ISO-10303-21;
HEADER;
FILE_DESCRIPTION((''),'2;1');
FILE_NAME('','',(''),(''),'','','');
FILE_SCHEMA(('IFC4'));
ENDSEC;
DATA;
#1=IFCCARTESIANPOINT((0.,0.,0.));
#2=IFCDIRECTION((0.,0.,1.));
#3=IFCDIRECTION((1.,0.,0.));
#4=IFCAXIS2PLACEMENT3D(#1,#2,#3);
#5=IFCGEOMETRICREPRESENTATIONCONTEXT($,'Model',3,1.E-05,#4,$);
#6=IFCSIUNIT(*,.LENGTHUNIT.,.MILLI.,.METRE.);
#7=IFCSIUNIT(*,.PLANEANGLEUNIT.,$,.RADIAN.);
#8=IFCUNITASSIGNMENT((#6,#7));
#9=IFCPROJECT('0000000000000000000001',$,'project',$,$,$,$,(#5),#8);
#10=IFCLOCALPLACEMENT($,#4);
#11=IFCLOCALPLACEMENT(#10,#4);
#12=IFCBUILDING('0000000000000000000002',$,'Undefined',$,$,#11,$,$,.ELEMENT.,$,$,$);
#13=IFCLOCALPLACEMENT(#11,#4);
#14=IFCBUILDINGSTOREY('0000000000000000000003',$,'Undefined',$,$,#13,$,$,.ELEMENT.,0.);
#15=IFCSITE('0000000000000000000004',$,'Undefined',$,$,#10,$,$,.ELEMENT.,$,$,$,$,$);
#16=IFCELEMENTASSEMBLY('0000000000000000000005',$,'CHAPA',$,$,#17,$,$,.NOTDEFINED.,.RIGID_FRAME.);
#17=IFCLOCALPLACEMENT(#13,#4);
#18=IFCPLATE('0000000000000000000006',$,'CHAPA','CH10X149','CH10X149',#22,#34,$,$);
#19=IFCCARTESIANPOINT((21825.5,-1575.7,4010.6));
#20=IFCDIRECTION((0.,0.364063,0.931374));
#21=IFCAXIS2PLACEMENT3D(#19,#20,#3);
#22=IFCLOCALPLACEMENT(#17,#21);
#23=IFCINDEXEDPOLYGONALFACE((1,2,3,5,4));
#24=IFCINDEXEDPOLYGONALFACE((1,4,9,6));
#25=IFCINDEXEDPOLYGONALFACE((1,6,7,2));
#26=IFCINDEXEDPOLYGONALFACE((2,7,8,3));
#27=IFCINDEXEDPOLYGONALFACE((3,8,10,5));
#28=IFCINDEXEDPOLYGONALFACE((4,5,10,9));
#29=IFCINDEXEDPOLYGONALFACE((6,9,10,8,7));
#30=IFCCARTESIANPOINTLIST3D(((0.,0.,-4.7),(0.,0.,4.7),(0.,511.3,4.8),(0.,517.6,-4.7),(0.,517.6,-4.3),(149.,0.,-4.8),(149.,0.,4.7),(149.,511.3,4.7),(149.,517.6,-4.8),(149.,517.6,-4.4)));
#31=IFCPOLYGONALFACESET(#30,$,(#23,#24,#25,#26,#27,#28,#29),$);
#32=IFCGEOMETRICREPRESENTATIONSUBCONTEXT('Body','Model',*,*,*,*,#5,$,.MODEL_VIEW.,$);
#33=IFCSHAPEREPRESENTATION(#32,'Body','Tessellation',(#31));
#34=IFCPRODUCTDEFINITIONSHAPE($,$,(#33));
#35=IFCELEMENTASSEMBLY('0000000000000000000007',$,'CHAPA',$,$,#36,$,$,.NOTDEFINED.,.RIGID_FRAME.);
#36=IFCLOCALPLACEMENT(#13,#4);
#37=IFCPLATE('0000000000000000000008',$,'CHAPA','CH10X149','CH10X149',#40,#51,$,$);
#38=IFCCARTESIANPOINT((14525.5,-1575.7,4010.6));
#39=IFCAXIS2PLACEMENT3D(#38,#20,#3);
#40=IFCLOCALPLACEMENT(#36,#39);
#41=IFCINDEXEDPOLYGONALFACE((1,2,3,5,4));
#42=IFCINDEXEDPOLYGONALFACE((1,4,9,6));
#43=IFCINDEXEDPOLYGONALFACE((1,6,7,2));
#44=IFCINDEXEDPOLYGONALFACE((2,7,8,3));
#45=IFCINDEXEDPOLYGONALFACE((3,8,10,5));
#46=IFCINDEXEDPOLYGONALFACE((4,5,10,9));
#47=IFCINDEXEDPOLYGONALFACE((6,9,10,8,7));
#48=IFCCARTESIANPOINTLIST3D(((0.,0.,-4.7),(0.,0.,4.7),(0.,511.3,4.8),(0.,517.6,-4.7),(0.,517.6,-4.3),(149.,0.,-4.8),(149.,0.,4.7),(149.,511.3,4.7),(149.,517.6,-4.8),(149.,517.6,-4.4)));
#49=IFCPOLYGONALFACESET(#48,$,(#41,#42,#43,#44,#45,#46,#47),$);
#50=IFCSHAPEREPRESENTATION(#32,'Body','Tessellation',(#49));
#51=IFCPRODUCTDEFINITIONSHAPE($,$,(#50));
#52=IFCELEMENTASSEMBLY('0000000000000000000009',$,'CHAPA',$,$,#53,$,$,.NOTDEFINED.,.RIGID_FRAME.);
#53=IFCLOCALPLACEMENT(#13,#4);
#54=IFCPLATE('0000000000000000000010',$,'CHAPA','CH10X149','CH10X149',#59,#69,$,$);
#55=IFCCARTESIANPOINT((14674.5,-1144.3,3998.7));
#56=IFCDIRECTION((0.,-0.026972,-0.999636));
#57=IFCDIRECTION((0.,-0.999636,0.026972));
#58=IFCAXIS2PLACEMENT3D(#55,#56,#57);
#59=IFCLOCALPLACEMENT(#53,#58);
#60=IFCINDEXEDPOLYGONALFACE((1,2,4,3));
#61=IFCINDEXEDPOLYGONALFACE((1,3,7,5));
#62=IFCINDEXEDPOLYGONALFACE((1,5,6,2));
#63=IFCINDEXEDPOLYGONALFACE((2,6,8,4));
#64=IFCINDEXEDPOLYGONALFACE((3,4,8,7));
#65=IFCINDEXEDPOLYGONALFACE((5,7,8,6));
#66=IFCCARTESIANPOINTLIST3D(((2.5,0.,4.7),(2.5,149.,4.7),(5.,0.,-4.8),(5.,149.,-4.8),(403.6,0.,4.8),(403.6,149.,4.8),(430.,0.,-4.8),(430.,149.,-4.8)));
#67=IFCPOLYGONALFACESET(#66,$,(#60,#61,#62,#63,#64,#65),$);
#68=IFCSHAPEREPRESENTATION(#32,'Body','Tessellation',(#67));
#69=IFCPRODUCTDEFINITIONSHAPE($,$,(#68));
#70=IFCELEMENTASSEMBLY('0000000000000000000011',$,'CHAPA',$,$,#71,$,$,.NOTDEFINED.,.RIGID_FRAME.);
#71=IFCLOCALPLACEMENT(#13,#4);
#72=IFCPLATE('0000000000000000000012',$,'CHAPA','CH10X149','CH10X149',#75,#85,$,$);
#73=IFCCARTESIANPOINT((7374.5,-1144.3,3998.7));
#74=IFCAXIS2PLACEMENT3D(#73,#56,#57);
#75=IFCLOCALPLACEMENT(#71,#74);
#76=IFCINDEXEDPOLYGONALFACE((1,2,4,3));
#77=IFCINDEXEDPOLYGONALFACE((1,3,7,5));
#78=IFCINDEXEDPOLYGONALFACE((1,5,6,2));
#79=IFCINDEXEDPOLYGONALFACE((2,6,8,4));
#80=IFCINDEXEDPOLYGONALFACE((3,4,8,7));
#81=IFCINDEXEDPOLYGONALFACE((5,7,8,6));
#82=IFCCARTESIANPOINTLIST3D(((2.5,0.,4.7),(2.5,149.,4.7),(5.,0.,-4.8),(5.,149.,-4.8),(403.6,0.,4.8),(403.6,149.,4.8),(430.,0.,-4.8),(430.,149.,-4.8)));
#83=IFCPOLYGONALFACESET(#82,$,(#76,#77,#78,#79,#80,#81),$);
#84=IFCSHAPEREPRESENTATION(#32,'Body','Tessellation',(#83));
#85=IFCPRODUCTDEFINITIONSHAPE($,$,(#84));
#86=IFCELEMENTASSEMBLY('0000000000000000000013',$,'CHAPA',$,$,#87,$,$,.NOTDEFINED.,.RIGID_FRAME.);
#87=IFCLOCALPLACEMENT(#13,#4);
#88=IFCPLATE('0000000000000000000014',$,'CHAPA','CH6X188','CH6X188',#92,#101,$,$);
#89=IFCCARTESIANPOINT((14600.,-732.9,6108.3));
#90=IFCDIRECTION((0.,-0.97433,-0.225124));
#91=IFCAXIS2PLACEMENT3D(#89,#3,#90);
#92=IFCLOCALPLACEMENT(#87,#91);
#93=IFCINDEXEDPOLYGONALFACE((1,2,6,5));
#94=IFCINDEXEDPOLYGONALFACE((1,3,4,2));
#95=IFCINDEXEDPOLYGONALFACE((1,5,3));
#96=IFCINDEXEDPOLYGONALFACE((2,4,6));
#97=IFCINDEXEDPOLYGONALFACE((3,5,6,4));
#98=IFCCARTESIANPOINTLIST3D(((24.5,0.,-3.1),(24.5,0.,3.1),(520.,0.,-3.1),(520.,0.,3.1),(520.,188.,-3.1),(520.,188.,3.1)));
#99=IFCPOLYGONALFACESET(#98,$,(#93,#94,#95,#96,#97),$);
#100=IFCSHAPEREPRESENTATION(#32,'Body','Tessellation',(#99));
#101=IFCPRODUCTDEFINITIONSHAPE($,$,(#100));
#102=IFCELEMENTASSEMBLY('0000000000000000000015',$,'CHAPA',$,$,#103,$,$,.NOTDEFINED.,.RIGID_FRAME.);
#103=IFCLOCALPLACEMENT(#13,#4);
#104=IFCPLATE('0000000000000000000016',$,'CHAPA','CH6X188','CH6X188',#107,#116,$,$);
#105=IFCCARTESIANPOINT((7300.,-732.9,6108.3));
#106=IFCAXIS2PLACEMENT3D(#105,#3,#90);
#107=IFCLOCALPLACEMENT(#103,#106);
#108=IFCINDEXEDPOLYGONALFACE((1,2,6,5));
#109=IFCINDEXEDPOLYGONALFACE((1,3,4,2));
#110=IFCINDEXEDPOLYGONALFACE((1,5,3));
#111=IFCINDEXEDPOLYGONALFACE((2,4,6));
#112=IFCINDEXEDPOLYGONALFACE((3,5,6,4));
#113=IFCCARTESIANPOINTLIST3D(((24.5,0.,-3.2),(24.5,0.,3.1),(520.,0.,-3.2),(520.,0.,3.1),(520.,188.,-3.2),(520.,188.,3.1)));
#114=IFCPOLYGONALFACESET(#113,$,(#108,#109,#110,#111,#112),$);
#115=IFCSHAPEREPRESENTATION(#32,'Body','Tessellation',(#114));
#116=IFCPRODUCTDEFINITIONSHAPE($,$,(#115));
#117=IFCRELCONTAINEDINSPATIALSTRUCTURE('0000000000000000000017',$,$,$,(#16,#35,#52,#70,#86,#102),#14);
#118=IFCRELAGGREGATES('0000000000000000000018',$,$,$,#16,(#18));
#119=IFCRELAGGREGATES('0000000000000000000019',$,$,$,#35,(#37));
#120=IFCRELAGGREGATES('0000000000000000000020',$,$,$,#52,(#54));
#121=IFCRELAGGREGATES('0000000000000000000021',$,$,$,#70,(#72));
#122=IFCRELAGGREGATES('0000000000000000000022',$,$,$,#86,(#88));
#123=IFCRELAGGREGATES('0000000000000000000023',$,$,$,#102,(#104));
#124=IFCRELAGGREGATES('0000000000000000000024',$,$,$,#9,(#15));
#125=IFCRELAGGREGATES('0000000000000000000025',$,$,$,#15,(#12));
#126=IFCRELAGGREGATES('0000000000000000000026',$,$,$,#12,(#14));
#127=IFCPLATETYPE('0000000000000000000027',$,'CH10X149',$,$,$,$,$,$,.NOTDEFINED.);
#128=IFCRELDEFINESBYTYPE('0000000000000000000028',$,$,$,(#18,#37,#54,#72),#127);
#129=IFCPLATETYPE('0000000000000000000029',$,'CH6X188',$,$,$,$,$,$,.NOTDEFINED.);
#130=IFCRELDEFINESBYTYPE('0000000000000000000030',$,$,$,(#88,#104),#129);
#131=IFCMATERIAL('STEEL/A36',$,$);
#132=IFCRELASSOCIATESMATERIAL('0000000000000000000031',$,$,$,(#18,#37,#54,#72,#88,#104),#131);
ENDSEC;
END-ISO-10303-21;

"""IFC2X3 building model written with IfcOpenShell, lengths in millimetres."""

from ifc_helpers import new_model, si_unit, frame, origin_with_axes, place, context, subcontext, project, spatial, polyline, outline, extrude, clip, halfspace, material, type_object, element, aggregate, save


model = new_model("IFC2X3")

# Units and contexts
model_context = context("Model", 3, precision=1e-05, world=origin_with_axes())
body_context = subcontext(model_context, "Body", "Model", "MODEL_VIEW")
ifc_project = project(units=[si_unit("LENGTHUNIT", "METRE", prefix="MILLI"), si_unit("PLANEANGLEUNIT", "RADIAN")], contexts=[model_context])

# Site, building, storey
site_placement = place(None, origin_with_axes())
site = spatial("IfcSite", under=ifc_project, at=site_placement, Name="Undefined", CompositionType="ELEMENT")
building_placement = place(site_placement, origin_with_axes())
building = spatial("IfcBuilding", under=site, at=building_placement, Name="Undefined", CompositionType="ELEMENT")
storey_placement = place(building_placement, origin_with_axes())
storey = spatial("IfcBuildingStorey", under=building, at=storey_placement, Name="Undefined", CompositionType="ELEMENT", Elevation=0.0)

# Shared definitions
ifc_material_1 = material(Name="STEEL/A36")

# Element assemblies, plates
assembly_1_placement = place(storey_placement, origin_with_axes())
assembly_1 = element("IfcElementAssembly", 1, at=assembly_1_placement, inside=storey, Name="CHAPA", AssemblyPlace="NOTDEFINED", PredefinedType="RIGID_FRAME")
plate_type_1 = type_object("IfcPlateType", Name="CH10X149", PredefinedType="NOTDEFINED")
plate_1_placement = place(assembly_1_placement, frame((21825.5, -1575.7, 4010.6), z_axis=(0.0, 0.364063, 0.931374), x_axis=(1.0, 0.0, 0.0)))
plate_1 = element("IfcPlate", 2, at=plate_1_placement, type_object=plate_type_1, material=ifc_material_1, Name="CHAPA", Description="CH10X149", ObjectType="CH10X149", context=body_context, shape_type="Clipping", body=[
    clip(extrude(outline(polyline([(0.0, 0.0), (149.0, 0.0), (149.0, 517.6), (0.0, 517.6), (0.0, 0.0)])), frame((0.0, 0.0, -4.8), z_axis=(0.0, 0.0, 1.0), x_axis=(1.0, 0.0, 0.0)), (0.0, 0.0, 1.0), 9.5), halfspace(frame((149.0, 517.9, -4.7), z_axis=(0.0, 0.821204, 0.570634), x_axis=(0.0, -0.570634, 0.821204)), False)),
])
aggregate(assembly_1, [plate_1])
assembly_2_placement = place(storey_placement, origin_with_axes())
assembly_2 = element("IfcElementAssembly", 3, at=assembly_2_placement, inside=storey, Name="CHAPA", AssemblyPlace="NOTDEFINED", PredefinedType="RIGID_FRAME")
plate_2_placement = place(assembly_2_placement, frame((14525.5, -1575.7, 4010.6), z_axis=(0.0, 0.364063, 0.931374), x_axis=(1.0, 0.0, 0.0)))
plate_2 = element("IfcPlate", 4, at=plate_2_placement, type_object=plate_type_1, material=ifc_material_1, Name="CHAPA", Description="CH10X149", ObjectType="CH10X149", context=body_context, shape_type="Clipping", body=[
    clip(extrude(outline(polyline([(0.0, 0.0), (149.0, 0.0), (149.0, 517.6), (0.0, 517.6), (0.0, 0.0)])), frame((0.0, 0.0, -4.8), z_axis=(0.0, 0.0, 1.0), x_axis=(1.0, 0.0, 0.0)), (0.0, 0.0, 1.0), 9.5), halfspace(frame((149.0, 517.9, -4.7), z_axis=(0.0, 0.821204, 0.570634), x_axis=(0.0, -0.570634, 0.821204)), False)),
])
aggregate(assembly_2, [plate_2])
assembly_3_placement = place(storey_placement, origin_with_axes())
assembly_3 = element("IfcElementAssembly", 5, at=assembly_3_placement, inside=storey, Name="CHAPA", AssemblyPlace="NOTDEFINED", PredefinedType="RIGID_FRAME")
plate_3_placement = place(assembly_3_placement, frame((14674.5, -1144.3, 3998.7), z_axis=(0.0, -0.026972, -0.999636), x_axis=(0.0, -0.999636, 0.026972)))
plate_3 = element("IfcPlate", 6, at=plate_3_placement, type_object=plate_type_1, material=ifc_material_1, Name="CHAPA", Description="CH10X149", ObjectType="CH10X149", context=body_context, shape_type="Clipping", body=[
    clip(clip(extrude(outline(polyline([(0.0, 0.0), (430.0, 0.0), (430.0, 149.0), (0.0, 149.0), (0.0, 0.0)])), frame((0.0, 0.0, -4.8), z_axis=(0.0, 0.0, 1.0), x_axis=(1.0, 0.0, 0.0)), (0.0, 0.0, 1.0), 9.5), halfspace(frame((403.6, -500.0, 4.7), z_axis=(0.33881, 0.0, 0.940855), x_axis=(0.0, 1.0, 0.0)), False)), halfspace(frame((5.0, -500.0, -4.8), z_axis=(-0.965989, 0.0, -0.258583), x_axis=(0.0, 1.0, 0.0)), False)),
])
aggregate(assembly_3, [plate_3])
assembly_4_placement = place(storey_placement, origin_with_axes())
assembly_4 = element("IfcElementAssembly", 7, at=assembly_4_placement, inside=storey, Name="CHAPA", AssemblyPlace="NOTDEFINED", PredefinedType="RIGID_FRAME")
plate_4_placement = place(assembly_4_placement, frame((7374.5, -1144.3, 3998.7), z_axis=(0.0, -0.026972, -0.999636), x_axis=(0.0, -0.999636, 0.026972)))
plate_4 = element("IfcPlate", 8, at=plate_4_placement, type_object=plate_type_1, material=ifc_material_1, Name="CHAPA", Description="CH10X149", ObjectType="CH10X149", context=body_context, shape_type="Clipping", body=[
    clip(clip(extrude(outline(polyline([(0.0, 0.0), (430.0, 0.0), (430.0, 149.0), (0.0, 149.0), (0.0, 0.0)])), frame((0.0, 0.0, -4.8), z_axis=(0.0, 0.0, 1.0), x_axis=(1.0, 0.0, 0.0)), (0.0, 0.0, 1.0), 9.5), halfspace(frame((403.6, -500.0, 4.7), z_axis=(0.33881, 0.0, 0.940855), x_axis=(0.0, 1.0, 0.0)), False)), halfspace(frame((5.0, -500.0, -4.8), z_axis=(-0.965989, 0.0, -0.258583), x_axis=(0.0, 1.0, 0.0)), False)),
])
aggregate(assembly_4, [plate_4])
assembly_5_placement = place(storey_placement, origin_with_axes())
assembly_5 = element("IfcElementAssembly", 9, at=assembly_5_placement, inside=storey, Name="CHAPA", AssemblyPlace="NOTDEFINED", PredefinedType="RIGID_FRAME")
plate_type_2 = type_object("IfcPlateType", Name="CH6X188", PredefinedType="NOTDEFINED")
plate_5_placement = place(assembly_5_placement, frame((14600.0, -732.9, 6108.3), z_axis=(1.0, 0.0, 0.0), x_axis=(0.0, -0.97433, -0.225124)))
plate_5 = element("IfcPlate", 10, at=plate_5_placement, type_object=plate_type_2, material=ifc_material_1, Name="CHAPA", Description="CH6X188", ObjectType="CH6X188", context=body_context, shape_type="Clipping", body=[
    clip(extrude(outline(polyline([(0.0, 0.0), (520.0, 0.0), (520.0, 191.6), (0.0, 0.0)])), frame((0.0, 0.0, -3.1), z_axis=(0.0, 0.0, 1.0), x_axis=(1.0, 0.0, 0.0)), (0.0, 0.0, 1.0), 6.3), halfspace(frame((1342.2, 500.0, 3.2), z_axis=(-0.354778, 0.934951, 0.0), x_axis=(-0.934951, -0.354778, 0.0)), False)),
])
aggregate(assembly_5, [plate_5])
assembly_6_placement = place(storey_placement, origin_with_axes())
assembly_6 = element("IfcElementAssembly", 11, at=assembly_6_placement, inside=storey, Name="CHAPA", AssemblyPlace="NOTDEFINED", PredefinedType="RIGID_FRAME")
plate_6_placement = place(assembly_6_placement, frame((7300.0, -732.9, 6108.3), z_axis=(1.0, 0.0, 0.0), x_axis=(0.0, -0.97433, -0.225124)))
plate_6 = element("IfcPlate", 12, at=plate_6_placement, type_object=plate_type_2, material=ifc_material_1, Name="CHAPA", Description="CH6X188", ObjectType="CH6X188", context=body_context, shape_type="Clipping", body=[
    clip(extrude(outline(polyline([(0.0, 0.0), (520.0, 0.0), (520.0, 191.6), (0.0, 0.0)])), frame((0.0, 0.0, -3.1), z_axis=(0.0, 0.0, 1.0), x_axis=(1.0, 0.0, 0.0)), (0.0, 0.0, 1.0), 6.3), halfspace(frame((1342.2, 500.0, 3.2), z_axis=(-0.354778, 0.934951, 0.0), x_axis=(-0.934951, -0.354778, 0.0)), False)),
])
aggregate(assembly_6, [plate_6])

save(model, "model.ifc")
